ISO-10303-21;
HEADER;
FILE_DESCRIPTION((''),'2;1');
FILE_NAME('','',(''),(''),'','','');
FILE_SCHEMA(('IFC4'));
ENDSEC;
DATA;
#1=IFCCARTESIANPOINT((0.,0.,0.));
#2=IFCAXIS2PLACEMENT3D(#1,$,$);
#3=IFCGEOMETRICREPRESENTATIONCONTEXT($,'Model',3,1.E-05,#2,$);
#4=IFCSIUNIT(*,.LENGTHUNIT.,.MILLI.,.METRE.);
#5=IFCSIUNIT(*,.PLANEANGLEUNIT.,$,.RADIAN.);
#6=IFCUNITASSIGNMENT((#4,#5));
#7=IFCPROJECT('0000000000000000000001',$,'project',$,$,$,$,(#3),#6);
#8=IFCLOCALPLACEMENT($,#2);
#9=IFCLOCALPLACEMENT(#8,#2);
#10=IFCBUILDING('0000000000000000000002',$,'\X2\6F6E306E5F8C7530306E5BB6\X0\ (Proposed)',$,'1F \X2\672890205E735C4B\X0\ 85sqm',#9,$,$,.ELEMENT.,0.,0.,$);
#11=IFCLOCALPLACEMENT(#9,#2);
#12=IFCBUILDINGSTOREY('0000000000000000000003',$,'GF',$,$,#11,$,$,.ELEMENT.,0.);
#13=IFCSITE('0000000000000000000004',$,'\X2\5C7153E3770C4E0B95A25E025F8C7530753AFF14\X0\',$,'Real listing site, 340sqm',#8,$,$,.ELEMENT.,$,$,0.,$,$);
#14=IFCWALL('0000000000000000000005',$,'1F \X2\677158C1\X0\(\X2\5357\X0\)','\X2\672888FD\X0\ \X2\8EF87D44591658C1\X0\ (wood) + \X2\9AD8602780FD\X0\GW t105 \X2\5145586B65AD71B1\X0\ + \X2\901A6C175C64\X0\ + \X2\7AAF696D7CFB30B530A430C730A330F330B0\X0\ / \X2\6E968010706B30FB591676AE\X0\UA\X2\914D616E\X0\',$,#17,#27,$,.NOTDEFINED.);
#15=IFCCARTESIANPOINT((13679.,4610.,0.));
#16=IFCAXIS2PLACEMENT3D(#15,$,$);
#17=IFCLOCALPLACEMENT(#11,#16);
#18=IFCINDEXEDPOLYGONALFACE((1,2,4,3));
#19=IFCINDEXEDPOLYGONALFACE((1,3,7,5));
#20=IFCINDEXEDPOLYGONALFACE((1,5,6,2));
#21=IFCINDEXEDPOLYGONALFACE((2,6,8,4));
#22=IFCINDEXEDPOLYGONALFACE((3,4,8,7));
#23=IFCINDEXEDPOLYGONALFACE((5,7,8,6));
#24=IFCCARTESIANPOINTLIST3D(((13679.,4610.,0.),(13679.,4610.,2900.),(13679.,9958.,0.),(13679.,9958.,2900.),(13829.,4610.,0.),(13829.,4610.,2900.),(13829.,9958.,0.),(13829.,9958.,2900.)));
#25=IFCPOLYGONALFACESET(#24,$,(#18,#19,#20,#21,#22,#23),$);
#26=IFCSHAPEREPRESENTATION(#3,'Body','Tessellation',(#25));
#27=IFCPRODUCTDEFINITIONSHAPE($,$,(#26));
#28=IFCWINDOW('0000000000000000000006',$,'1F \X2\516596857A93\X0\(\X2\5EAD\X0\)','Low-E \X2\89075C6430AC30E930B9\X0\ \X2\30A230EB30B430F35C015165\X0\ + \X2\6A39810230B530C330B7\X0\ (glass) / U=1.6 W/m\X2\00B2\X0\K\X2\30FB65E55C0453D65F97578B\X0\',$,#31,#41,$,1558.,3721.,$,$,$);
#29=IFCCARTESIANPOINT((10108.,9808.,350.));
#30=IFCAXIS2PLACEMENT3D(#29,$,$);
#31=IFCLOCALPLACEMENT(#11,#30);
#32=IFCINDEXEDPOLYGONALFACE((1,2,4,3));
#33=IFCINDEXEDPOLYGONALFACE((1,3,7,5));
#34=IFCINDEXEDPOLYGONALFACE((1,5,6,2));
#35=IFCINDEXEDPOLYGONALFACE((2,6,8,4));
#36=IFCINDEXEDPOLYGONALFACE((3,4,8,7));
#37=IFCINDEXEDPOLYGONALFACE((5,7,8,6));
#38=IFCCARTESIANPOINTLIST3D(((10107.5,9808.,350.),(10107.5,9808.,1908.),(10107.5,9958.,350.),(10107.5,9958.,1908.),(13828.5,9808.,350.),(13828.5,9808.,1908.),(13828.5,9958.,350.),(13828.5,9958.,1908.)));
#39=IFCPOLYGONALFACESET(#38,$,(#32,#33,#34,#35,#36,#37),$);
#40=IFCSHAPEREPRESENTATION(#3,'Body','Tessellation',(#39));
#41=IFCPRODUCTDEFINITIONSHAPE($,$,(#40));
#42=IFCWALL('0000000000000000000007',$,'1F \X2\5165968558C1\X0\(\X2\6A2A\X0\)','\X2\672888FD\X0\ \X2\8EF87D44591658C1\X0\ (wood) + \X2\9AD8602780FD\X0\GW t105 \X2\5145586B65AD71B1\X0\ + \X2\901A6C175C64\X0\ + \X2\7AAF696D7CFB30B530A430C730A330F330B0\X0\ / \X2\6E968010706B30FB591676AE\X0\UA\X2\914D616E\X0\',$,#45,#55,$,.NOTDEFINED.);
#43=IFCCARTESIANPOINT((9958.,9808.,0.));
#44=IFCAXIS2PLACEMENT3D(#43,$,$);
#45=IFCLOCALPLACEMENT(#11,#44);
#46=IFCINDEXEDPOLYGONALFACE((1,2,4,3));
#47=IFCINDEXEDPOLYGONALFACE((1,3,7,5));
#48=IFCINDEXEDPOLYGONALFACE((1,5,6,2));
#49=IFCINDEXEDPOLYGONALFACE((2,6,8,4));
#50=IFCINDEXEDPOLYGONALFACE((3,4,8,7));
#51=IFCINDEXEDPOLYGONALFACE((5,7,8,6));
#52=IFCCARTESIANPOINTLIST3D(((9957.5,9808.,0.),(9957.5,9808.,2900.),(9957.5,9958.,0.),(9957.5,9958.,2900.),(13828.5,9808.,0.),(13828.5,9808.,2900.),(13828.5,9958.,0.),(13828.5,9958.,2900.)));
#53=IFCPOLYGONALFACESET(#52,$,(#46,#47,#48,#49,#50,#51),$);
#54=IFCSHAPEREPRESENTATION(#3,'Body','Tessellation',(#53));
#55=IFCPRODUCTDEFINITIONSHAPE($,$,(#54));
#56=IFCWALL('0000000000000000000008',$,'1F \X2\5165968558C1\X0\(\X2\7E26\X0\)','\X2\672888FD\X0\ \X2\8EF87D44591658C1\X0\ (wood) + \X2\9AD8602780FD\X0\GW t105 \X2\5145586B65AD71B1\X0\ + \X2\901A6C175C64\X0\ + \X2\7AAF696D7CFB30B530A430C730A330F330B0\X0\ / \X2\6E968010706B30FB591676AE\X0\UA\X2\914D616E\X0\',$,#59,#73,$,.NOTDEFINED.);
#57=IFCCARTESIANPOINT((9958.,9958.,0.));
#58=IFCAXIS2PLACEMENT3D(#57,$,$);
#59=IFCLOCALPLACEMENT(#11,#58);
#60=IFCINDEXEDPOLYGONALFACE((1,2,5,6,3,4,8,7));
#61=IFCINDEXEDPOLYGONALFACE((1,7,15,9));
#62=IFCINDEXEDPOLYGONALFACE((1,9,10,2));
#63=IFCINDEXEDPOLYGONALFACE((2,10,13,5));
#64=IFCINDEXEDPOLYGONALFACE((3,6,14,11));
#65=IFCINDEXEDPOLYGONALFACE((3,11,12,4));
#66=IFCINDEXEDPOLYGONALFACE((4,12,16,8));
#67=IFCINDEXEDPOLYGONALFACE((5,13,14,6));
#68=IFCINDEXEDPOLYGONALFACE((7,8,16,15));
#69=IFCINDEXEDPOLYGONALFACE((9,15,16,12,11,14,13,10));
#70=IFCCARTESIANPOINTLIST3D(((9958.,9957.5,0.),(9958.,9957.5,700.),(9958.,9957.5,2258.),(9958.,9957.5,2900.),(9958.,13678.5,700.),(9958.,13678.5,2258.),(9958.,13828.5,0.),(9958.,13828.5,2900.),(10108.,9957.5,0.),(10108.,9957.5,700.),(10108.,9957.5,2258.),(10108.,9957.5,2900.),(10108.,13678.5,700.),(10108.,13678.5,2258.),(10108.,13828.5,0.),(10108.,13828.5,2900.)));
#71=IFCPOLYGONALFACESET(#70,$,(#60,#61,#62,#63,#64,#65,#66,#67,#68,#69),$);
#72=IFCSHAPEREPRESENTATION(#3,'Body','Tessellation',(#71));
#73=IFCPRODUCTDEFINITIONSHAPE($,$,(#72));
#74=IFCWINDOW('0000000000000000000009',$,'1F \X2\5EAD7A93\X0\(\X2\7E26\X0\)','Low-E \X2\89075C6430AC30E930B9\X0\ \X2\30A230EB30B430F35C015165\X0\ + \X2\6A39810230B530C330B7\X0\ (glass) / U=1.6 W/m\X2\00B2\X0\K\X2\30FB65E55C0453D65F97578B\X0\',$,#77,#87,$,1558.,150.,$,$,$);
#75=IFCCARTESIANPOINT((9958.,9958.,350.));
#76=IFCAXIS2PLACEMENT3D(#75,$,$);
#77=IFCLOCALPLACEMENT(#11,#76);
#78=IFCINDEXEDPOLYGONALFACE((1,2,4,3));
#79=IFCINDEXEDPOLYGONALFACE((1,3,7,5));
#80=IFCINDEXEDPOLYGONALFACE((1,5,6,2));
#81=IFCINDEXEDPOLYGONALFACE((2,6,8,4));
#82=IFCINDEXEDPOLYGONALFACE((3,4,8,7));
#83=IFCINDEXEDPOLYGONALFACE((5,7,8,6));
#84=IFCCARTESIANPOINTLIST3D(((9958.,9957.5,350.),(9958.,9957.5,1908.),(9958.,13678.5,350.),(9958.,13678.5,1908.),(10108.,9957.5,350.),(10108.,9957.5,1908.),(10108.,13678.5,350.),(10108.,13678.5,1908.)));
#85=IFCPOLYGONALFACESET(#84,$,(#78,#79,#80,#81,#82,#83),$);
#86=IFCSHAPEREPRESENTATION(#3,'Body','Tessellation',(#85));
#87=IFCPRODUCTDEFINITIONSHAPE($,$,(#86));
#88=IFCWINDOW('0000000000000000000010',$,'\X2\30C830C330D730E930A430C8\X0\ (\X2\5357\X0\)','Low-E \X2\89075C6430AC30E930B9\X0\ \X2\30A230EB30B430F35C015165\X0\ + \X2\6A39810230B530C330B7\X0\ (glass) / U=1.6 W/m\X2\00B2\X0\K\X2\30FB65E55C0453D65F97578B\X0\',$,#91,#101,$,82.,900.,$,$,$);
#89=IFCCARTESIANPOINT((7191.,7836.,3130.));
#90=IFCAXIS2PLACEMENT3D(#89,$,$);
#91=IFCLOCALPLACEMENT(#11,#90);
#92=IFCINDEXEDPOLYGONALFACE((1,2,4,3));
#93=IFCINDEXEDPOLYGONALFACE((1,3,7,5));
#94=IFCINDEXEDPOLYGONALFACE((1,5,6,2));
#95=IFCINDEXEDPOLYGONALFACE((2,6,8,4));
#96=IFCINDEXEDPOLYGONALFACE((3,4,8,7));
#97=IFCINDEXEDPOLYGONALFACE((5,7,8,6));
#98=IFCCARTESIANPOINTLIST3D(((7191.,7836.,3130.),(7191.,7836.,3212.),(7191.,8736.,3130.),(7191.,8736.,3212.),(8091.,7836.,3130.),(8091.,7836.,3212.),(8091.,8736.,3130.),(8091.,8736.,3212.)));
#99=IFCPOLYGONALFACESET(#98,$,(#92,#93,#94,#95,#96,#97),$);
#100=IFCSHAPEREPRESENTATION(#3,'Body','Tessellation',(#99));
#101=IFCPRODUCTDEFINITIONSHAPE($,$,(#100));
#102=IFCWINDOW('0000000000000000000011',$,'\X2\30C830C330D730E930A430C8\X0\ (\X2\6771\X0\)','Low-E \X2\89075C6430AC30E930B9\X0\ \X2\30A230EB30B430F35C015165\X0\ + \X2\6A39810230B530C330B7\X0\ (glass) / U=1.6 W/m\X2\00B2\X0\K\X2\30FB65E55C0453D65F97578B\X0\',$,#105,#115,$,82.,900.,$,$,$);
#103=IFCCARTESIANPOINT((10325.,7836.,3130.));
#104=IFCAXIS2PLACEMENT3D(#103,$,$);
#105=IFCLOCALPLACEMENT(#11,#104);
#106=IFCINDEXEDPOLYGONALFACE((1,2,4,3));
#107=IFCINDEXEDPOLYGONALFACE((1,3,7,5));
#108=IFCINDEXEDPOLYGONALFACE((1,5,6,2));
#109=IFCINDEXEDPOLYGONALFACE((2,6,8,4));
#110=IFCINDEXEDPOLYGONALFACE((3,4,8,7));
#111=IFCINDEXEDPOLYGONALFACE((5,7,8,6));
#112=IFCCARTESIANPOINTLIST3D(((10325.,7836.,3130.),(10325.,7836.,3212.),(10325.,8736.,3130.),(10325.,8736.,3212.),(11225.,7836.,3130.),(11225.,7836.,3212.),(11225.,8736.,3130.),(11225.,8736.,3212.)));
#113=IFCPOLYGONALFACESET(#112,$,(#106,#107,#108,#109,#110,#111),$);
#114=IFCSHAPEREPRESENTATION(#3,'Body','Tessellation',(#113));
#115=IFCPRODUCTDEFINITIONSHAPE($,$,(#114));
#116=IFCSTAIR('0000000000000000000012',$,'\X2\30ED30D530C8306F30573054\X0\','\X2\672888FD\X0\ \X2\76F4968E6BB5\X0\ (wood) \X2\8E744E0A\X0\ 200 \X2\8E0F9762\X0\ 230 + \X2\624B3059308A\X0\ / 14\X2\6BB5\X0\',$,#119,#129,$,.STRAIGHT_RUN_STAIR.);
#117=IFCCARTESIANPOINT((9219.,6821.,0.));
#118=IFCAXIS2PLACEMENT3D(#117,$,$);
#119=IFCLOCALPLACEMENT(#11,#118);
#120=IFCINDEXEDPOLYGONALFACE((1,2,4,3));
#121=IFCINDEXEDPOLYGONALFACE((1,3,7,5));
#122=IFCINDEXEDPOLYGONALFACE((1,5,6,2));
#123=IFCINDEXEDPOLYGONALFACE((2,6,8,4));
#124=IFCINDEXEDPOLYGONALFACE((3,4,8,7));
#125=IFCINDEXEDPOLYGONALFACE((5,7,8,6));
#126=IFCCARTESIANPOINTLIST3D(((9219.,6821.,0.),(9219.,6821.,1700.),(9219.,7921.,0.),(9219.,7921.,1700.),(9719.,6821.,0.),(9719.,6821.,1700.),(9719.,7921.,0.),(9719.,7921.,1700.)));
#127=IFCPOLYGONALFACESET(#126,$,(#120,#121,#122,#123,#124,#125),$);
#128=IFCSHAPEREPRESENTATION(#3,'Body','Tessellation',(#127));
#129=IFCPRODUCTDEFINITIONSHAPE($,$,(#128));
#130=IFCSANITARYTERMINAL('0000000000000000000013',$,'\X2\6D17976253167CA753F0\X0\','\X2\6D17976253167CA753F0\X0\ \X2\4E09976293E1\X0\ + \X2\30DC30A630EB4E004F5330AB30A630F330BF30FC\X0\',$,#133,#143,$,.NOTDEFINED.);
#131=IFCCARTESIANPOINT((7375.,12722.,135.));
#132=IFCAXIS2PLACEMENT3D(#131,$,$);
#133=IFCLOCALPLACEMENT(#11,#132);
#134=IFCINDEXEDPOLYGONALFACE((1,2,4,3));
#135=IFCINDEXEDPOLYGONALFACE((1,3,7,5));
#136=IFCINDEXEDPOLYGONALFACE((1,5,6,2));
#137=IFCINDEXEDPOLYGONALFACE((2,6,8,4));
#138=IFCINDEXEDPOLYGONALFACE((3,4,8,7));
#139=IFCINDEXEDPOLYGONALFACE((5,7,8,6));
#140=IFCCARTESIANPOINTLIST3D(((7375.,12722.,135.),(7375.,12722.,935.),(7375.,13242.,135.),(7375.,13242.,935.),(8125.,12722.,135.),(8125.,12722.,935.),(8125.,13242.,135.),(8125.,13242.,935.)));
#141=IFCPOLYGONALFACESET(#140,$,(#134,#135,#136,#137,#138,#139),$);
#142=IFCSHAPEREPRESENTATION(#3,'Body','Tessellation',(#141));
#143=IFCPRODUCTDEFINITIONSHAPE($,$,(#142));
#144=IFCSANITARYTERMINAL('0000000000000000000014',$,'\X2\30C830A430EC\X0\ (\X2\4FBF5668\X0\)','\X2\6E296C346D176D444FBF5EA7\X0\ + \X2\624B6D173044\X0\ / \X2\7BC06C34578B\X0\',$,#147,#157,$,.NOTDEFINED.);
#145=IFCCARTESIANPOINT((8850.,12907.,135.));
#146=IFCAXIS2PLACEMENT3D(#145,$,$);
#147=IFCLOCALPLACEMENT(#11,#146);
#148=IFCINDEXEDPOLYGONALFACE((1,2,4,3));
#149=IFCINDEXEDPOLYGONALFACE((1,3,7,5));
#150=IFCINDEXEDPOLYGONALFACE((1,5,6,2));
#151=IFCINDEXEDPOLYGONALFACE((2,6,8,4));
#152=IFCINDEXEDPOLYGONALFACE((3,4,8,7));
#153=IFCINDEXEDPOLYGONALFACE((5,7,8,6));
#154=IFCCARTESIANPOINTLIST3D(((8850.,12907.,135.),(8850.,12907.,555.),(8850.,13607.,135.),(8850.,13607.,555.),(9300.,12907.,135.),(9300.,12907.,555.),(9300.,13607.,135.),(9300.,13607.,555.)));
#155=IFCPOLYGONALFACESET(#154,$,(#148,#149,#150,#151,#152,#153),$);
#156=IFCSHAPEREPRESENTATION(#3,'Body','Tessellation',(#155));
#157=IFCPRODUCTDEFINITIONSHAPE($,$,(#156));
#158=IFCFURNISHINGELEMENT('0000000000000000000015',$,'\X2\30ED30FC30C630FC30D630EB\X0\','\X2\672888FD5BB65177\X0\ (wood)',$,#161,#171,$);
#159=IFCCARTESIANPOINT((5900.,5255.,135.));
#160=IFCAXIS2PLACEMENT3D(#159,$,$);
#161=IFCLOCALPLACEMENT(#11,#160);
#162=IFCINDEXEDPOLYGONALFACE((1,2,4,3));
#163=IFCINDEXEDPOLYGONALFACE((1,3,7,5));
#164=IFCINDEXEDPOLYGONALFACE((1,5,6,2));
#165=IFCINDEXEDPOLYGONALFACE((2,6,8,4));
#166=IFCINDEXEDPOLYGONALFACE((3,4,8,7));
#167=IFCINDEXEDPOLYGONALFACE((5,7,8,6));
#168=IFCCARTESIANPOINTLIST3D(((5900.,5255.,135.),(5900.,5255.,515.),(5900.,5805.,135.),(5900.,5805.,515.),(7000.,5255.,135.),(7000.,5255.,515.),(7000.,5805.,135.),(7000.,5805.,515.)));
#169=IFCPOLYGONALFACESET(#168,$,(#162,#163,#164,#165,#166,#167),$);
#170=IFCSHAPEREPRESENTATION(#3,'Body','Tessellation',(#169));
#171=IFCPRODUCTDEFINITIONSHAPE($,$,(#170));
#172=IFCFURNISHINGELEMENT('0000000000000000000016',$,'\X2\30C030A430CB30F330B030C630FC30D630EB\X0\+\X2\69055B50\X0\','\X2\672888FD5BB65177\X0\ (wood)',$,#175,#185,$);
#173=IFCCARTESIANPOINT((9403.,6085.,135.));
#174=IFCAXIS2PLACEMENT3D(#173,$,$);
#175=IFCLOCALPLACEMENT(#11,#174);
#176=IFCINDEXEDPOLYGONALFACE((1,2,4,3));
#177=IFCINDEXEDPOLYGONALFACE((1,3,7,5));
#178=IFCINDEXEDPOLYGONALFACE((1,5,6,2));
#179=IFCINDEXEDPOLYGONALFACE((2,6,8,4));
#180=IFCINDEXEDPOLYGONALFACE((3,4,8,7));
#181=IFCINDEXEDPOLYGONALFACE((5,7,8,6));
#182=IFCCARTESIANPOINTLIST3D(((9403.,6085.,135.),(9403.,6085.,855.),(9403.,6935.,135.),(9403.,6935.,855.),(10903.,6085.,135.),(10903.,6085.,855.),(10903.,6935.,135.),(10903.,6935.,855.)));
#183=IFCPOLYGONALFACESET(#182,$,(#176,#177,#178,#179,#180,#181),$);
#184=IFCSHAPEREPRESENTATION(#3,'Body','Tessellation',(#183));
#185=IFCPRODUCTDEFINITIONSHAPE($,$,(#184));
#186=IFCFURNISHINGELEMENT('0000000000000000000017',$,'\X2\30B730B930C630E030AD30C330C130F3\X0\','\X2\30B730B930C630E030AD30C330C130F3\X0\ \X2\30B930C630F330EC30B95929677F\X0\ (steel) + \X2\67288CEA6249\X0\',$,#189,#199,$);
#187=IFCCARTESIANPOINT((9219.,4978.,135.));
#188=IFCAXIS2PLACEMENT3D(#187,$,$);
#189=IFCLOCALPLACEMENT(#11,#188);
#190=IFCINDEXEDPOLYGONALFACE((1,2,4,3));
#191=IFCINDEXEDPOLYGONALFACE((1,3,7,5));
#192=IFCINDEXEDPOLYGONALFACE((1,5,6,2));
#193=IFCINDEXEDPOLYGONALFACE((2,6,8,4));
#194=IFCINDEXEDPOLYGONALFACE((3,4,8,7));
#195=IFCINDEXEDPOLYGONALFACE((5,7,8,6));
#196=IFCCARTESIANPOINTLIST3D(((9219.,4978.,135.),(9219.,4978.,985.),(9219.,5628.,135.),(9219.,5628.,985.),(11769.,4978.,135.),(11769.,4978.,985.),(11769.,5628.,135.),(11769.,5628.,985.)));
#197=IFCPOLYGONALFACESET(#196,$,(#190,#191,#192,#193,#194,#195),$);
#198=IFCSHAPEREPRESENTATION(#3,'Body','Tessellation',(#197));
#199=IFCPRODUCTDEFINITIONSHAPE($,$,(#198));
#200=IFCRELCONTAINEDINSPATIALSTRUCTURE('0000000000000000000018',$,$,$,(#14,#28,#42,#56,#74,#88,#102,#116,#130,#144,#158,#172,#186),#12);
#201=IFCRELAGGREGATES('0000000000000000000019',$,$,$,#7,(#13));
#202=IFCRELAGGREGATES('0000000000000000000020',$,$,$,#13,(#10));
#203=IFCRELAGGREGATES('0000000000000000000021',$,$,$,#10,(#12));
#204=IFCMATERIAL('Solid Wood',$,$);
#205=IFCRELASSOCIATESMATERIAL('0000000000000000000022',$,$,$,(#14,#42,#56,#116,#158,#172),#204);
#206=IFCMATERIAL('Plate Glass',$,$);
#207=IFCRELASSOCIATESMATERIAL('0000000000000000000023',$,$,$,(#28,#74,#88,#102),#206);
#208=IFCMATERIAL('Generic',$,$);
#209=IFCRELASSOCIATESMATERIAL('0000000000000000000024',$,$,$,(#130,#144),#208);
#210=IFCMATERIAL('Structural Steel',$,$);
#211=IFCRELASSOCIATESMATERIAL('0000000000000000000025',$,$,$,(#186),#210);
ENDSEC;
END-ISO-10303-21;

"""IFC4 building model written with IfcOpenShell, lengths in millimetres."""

from ifc_helpers import new_model, si_unit, frame, frame_2d, origin, place, context, project, spatial, rectangle, extrude, material, element, fill, save


model = new_model("IFC4")

# Units and contexts
model_context = context("Model", 3, precision=1e-05, world=origin())
ifc_project = project(units=[si_unit("LENGTHUNIT", "METRE", prefix="MILLI"), si_unit("PLANEANGLEUNIT", "RADIAN")], contexts=[model_context])

# Site, building, storey
site_placement = place(None, origin())
site = spatial("IfcSite", under=ifc_project, at=site_placement, Name="山口県下関市後田町４", ObjectType="Real listing site, 340sqm", CompositionType="ELEMENT", RefElevation=0.0)
building_placement = place(site_placement, origin())
building = spatial("IfcBuilding", under=site, at=building_placement, Name="潮の後田の家 (Proposed)", ObjectType="1F 木造平屋 85sqm", CompositionType="ELEMENT", ElevationOfRefHeight=0.0, ElevationOfTerrain=0.0)
storey_placement = place(building_placement, origin())
storey = spatial("IfcBuildingStorey", under=building, at=storey_placement, Name="GF", CompositionType="ELEMENT", Elevation=0.0)

# Shared definitions
ifc_material_1 = material(Name="Solid Wood")

# Wall, opening, window
wall_1_placement = place(storey_placement, frame((13679.0, 4610.0, 0.0)))
wall_1 = element("IfcWall", 1, at=wall_1_placement, inside=storey, material=ifc_material_1, Name="1F 東壁(南)", Description="木製 軸組外壁 (wood) + 高性能GW t105 充填断熱 + 通気層 + 窯業系サイディング / 準耐火・外皮UA配慮", PredefinedType="NOTDEFINED", context=model_context, shape_type="SweptSolid", body=[
    extrude(rectangle(XDim=150.0, YDim=5348.0, at=frame_2d((75.0, 2674.0))), frame((13679.0, 4610.0, 0.0)), (0.0, 0.0, 1.0), 2900.0),
])
opening_1_placement = place(storey_placement, frame((10108.0, 9808.0, 350.0)))
opening_1 = element("IfcOpeningElement", 2, at=opening_1_placement, cuts=wall_1, PredefinedType="NOTDEFINED", context=model_context, shape_type="SweptSolid", body=[
    extrude(rectangle(XDim=3721.0, YDim=150.0, at=frame_2d((1860.0, 75.0))), frame((10108.0, 9808.0, 350.0)), (0.0, 0.0, 1.0), 1558.0),
])
ifc_material_2 = material(Name="Plate Glass")
window_1_placement = place(storey_placement, frame((10108.0, 9808.0, 350.0)))
window_1 = element("IfcWindow", 3, at=window_1_placement, inside=storey, material=ifc_material_2, Name="1F 入隅窓(庭)", Description="Low-E 複層ガラス アルゴン封入 + 樹脂サッシ (glass) / U=1.6 W/m²K・日射取得型", OverallHeight=1558.0, OverallWidth=3721.0, context=model_context, shape_type="SweptSolid", body=[
    extrude(rectangle(XDim=3721.0, YDim=150.0, at=frame_2d((1860.0, 75.0))), frame((10108.0, 9808.0, 350.0)), (0.0, 0.0, 1.0), 1558.0),
])
fill(opening_1, window_1)

# Wall
wall_2_placement = place(storey_placement, frame((9958.0, 9808.0, 0.0)))
element("IfcWall", 4, at=wall_2_placement, inside=storey, material=ifc_material_1, Name="1F 入隅壁(横)", Description="木製 軸組外壁 (wood) + 高性能GW t105 充填断熱 + 通気層 + 窯業系サイディング / 準耐火・外皮UA配慮", PredefinedType="NOTDEFINED", context=model_context, shape_type="SweptSolid", body=[
    extrude(rectangle(XDim=3871.0, YDim=150.0, at=frame_2d((1935.0, 75.0))), frame((9958.0, 9808.0, 0.0)), (0.0, 0.0, 1.0), 2900.0),
])

# Wall, opening, window
wall_3_placement = place(storey_placement, frame((9958.0, 9958.0, 0.0)))
wall_3 = element("IfcWall", 5, at=wall_3_placement, inside=storey, material=ifc_material_1, Name="1F 入隅壁(縦)", Description="木製 軸組外壁 (wood) + 高性能GW t105 充填断熱 + 通気層 + 窯業系サイディング / 準耐火・外皮UA配慮", PredefinedType="NOTDEFINED", context=model_context, shape_type="SweptSolid", body=[
    extrude(rectangle(XDim=150.0, YDim=3871.0, at=frame_2d((75.0, 1935.0))), frame((9958.0, 9958.0, 0.0)), (0.0, 0.0, 1.0), 2900.0),
])
opening_2_placement = place(storey_placement, frame((9958.0, 9958.0, 350.0)))
opening_2 = element("IfcOpeningElement", 6, at=opening_2_placement, cuts=wall_3, PredefinedType="NOTDEFINED", context=model_context, shape_type="SweptSolid", body=[
    extrude(rectangle(XDim=150.0, YDim=3721.0, at=frame_2d((75.0, 1860.0))), frame((9958.0, 9958.0, 350.0)), (0.0, 0.0, 1.0), 1558.0),
])
window_2_placement = place(storey_placement, frame((9958.0, 9958.0, 350.0)))
window_2 = element("IfcWindow", 7, at=window_2_placement, inside=storey, material=ifc_material_2, Name="1F 庭窓(縦)", Description="Low-E 複層ガラス アルゴン封入 + 樹脂サッシ (glass) / U=1.6 W/m²K・日射取得型", OverallHeight=1558.0, OverallWidth=150.0, context=model_context, shape_type="SweptSolid", body=[
    extrude(rectangle(XDim=150.0, YDim=3721.0, at=frame_2d((75.0, 1860.0))), frame((9958.0, 9958.0, 350.0)), (0.0, 0.0, 1.0), 1558.0),
])
fill(opening_2, window_2)

# Windows
window_3_placement = place(storey_placement, frame((7191.0, 7836.0, 3130.0)))
element("IfcWindow", 8, at=window_3_placement, inside=storey, material=ifc_material_2, Name="トップライト (南)", Description="Low-E 複層ガラス アルゴン封入 + 樹脂サッシ (glass) / U=1.6 W/m²K・日射取得型", OverallHeight=82.0, OverallWidth=900.0, context=model_context, shape_type="SweptSolid", body=[
    extrude(rectangle(XDim=900.0, YDim=900.0, at=frame_2d((450.0, 450.0))), frame((7191.0, 7836.0, 3130.0)), (0.0, 0.0, 1.0), 82.0),
])
window_4_placement = place(storey_placement, frame((10325.0, 7836.0, 3130.0)))
element("IfcWindow", 9, at=window_4_placement, inside=storey, material=ifc_material_2, Name="トップライト (東)", Description="Low-E 複層ガラス アルゴン封入 + 樹脂サッシ (glass) / U=1.6 W/m²K・日射取得型", OverallHeight=82.0, OverallWidth=900.0, context=model_context, shape_type="SweptSolid", body=[
    extrude(rectangle(XDim=900.0, YDim=900.0, at=frame_2d((450.0, 450.0))), frame((10325.0, 7836.0, 3130.0)), (0.0, 0.0, 1.0), 82.0),
])

# Stair
stair_placement = place(storey_placement, frame((9219.0, 6821.0, 0.0)))
element("IfcStair", 10, at=stair_placement, inside=storey, material=ifc_material_1, Name="ロフトはしご", Description="木製 直階段 (wood) 蹴上 200 踏面 230 + 手すり / 14段", PredefinedType="STRAIGHT_RUN_STAIR", context=model_context, shape_type="SweptSolid", body=[
    extrude(rectangle(XDim=500.0, YDim=1100.0, at=frame_2d((250.0, 550.0))), frame((9219.0, 6821.0, 0.0)), (0.0, 0.0, 1.0), 1700.0),
])

# Sanitary terminals
ifc_material_3 = material(Name="Generic")
sanitary_terminal_1_placement = place(storey_placement, frame((7375.0, 12722.0, 135.0)))
element("IfcSanitaryTerminal", 11, at=sanitary_terminal_1_placement, inside=storey, material=ifc_material_3, Name="洗面化粧台", Description="洗面化粧台 三面鏡 + ボウル一体カウンター", PredefinedType="NOTDEFINED", context=model_context, shape_type="SweptSolid", body=[
    extrude(rectangle(XDim=750.0, YDim=520.0, at=frame_2d((375.0, 260.0))), frame((7375.0, 12722.0, 135.0)), (0.0, 0.0, 1.0), 800.0),
])
sanitary_terminal_2_placement = place(storey_placement, frame((8850.0, 12907.0, 135.0)))
element("IfcSanitaryTerminal", 12, at=sanitary_terminal_2_placement, inside=storey, material=ifc_material_3, Name="トイレ (便器)", Description="温水洗浄便座 + 手洗い / 節水型", PredefinedType="NOTDEFINED", context=model_context, shape_type="SweptSolid", body=[
    extrude(rectangle(XDim=450.0, YDim=700.0, at=frame_2d((225.0, 350.0))), frame((8850.0, 12907.0, 135.0)), (0.0, 0.0, 1.0), 420.0),
])

# Furnishing elements
furnishing_1_placement = place(storey_placement, frame((5900.0, 5255.0, 135.0)))
element("IfcFurnishingElement", 13, at=furnishing_1_placement, inside=storey, material=ifc_material_1, Name="ローテーブル", Description="木製家具 (wood)", context=model_context, shape_type="SweptSolid", body=[
    extrude(rectangle(XDim=1100.0, YDim=550.0, at=frame_2d((550.0, 275.0))), frame((5900.0, 5255.0, 135.0)), (0.0, 0.0, 1.0), 380.0),
])
furnishing_2_placement = place(storey_placement, frame((9403.0, 6085.0, 135.0)))
element("IfcFurnishingElement", 14, at=furnishing_2_placement, inside=storey, material=ifc_material_1, Name="ダイニングテーブル+椅子", Description="木製家具 (wood)", context=model_context, shape_type="SweptSolid", body=[
    extrude(rectangle(XDim=1500.0, YDim=850.0, at=frame_2d((750.0, 425.0))), frame((9403.0, 6085.0, 135.0)), (0.0, 0.0, 1.0), 720.0),
])
ifc_material_4 = material(Name="Structural Steel")
furnishing_3_placement = place(storey_placement, frame((9219.0, 4978.0, 135.0)))
element("IfcFurnishingElement", 15, at=furnishing_3_placement, inside=storey, material=ifc_material_4, Name="システムキッチン", Description="システムキッチン ステンレス天板 (steel) + 木質扉", context=model_context, shape_type="SweptSolid", body=[
    extrude(rectangle(XDim=2550.0, YDim=650.0, at=frame_2d((1275.0, 325.0))), frame((9219.0, 4978.0, 135.0)), (0.0, 0.0, 1.0), 850.0),
])

save(model, "model.ifc")
